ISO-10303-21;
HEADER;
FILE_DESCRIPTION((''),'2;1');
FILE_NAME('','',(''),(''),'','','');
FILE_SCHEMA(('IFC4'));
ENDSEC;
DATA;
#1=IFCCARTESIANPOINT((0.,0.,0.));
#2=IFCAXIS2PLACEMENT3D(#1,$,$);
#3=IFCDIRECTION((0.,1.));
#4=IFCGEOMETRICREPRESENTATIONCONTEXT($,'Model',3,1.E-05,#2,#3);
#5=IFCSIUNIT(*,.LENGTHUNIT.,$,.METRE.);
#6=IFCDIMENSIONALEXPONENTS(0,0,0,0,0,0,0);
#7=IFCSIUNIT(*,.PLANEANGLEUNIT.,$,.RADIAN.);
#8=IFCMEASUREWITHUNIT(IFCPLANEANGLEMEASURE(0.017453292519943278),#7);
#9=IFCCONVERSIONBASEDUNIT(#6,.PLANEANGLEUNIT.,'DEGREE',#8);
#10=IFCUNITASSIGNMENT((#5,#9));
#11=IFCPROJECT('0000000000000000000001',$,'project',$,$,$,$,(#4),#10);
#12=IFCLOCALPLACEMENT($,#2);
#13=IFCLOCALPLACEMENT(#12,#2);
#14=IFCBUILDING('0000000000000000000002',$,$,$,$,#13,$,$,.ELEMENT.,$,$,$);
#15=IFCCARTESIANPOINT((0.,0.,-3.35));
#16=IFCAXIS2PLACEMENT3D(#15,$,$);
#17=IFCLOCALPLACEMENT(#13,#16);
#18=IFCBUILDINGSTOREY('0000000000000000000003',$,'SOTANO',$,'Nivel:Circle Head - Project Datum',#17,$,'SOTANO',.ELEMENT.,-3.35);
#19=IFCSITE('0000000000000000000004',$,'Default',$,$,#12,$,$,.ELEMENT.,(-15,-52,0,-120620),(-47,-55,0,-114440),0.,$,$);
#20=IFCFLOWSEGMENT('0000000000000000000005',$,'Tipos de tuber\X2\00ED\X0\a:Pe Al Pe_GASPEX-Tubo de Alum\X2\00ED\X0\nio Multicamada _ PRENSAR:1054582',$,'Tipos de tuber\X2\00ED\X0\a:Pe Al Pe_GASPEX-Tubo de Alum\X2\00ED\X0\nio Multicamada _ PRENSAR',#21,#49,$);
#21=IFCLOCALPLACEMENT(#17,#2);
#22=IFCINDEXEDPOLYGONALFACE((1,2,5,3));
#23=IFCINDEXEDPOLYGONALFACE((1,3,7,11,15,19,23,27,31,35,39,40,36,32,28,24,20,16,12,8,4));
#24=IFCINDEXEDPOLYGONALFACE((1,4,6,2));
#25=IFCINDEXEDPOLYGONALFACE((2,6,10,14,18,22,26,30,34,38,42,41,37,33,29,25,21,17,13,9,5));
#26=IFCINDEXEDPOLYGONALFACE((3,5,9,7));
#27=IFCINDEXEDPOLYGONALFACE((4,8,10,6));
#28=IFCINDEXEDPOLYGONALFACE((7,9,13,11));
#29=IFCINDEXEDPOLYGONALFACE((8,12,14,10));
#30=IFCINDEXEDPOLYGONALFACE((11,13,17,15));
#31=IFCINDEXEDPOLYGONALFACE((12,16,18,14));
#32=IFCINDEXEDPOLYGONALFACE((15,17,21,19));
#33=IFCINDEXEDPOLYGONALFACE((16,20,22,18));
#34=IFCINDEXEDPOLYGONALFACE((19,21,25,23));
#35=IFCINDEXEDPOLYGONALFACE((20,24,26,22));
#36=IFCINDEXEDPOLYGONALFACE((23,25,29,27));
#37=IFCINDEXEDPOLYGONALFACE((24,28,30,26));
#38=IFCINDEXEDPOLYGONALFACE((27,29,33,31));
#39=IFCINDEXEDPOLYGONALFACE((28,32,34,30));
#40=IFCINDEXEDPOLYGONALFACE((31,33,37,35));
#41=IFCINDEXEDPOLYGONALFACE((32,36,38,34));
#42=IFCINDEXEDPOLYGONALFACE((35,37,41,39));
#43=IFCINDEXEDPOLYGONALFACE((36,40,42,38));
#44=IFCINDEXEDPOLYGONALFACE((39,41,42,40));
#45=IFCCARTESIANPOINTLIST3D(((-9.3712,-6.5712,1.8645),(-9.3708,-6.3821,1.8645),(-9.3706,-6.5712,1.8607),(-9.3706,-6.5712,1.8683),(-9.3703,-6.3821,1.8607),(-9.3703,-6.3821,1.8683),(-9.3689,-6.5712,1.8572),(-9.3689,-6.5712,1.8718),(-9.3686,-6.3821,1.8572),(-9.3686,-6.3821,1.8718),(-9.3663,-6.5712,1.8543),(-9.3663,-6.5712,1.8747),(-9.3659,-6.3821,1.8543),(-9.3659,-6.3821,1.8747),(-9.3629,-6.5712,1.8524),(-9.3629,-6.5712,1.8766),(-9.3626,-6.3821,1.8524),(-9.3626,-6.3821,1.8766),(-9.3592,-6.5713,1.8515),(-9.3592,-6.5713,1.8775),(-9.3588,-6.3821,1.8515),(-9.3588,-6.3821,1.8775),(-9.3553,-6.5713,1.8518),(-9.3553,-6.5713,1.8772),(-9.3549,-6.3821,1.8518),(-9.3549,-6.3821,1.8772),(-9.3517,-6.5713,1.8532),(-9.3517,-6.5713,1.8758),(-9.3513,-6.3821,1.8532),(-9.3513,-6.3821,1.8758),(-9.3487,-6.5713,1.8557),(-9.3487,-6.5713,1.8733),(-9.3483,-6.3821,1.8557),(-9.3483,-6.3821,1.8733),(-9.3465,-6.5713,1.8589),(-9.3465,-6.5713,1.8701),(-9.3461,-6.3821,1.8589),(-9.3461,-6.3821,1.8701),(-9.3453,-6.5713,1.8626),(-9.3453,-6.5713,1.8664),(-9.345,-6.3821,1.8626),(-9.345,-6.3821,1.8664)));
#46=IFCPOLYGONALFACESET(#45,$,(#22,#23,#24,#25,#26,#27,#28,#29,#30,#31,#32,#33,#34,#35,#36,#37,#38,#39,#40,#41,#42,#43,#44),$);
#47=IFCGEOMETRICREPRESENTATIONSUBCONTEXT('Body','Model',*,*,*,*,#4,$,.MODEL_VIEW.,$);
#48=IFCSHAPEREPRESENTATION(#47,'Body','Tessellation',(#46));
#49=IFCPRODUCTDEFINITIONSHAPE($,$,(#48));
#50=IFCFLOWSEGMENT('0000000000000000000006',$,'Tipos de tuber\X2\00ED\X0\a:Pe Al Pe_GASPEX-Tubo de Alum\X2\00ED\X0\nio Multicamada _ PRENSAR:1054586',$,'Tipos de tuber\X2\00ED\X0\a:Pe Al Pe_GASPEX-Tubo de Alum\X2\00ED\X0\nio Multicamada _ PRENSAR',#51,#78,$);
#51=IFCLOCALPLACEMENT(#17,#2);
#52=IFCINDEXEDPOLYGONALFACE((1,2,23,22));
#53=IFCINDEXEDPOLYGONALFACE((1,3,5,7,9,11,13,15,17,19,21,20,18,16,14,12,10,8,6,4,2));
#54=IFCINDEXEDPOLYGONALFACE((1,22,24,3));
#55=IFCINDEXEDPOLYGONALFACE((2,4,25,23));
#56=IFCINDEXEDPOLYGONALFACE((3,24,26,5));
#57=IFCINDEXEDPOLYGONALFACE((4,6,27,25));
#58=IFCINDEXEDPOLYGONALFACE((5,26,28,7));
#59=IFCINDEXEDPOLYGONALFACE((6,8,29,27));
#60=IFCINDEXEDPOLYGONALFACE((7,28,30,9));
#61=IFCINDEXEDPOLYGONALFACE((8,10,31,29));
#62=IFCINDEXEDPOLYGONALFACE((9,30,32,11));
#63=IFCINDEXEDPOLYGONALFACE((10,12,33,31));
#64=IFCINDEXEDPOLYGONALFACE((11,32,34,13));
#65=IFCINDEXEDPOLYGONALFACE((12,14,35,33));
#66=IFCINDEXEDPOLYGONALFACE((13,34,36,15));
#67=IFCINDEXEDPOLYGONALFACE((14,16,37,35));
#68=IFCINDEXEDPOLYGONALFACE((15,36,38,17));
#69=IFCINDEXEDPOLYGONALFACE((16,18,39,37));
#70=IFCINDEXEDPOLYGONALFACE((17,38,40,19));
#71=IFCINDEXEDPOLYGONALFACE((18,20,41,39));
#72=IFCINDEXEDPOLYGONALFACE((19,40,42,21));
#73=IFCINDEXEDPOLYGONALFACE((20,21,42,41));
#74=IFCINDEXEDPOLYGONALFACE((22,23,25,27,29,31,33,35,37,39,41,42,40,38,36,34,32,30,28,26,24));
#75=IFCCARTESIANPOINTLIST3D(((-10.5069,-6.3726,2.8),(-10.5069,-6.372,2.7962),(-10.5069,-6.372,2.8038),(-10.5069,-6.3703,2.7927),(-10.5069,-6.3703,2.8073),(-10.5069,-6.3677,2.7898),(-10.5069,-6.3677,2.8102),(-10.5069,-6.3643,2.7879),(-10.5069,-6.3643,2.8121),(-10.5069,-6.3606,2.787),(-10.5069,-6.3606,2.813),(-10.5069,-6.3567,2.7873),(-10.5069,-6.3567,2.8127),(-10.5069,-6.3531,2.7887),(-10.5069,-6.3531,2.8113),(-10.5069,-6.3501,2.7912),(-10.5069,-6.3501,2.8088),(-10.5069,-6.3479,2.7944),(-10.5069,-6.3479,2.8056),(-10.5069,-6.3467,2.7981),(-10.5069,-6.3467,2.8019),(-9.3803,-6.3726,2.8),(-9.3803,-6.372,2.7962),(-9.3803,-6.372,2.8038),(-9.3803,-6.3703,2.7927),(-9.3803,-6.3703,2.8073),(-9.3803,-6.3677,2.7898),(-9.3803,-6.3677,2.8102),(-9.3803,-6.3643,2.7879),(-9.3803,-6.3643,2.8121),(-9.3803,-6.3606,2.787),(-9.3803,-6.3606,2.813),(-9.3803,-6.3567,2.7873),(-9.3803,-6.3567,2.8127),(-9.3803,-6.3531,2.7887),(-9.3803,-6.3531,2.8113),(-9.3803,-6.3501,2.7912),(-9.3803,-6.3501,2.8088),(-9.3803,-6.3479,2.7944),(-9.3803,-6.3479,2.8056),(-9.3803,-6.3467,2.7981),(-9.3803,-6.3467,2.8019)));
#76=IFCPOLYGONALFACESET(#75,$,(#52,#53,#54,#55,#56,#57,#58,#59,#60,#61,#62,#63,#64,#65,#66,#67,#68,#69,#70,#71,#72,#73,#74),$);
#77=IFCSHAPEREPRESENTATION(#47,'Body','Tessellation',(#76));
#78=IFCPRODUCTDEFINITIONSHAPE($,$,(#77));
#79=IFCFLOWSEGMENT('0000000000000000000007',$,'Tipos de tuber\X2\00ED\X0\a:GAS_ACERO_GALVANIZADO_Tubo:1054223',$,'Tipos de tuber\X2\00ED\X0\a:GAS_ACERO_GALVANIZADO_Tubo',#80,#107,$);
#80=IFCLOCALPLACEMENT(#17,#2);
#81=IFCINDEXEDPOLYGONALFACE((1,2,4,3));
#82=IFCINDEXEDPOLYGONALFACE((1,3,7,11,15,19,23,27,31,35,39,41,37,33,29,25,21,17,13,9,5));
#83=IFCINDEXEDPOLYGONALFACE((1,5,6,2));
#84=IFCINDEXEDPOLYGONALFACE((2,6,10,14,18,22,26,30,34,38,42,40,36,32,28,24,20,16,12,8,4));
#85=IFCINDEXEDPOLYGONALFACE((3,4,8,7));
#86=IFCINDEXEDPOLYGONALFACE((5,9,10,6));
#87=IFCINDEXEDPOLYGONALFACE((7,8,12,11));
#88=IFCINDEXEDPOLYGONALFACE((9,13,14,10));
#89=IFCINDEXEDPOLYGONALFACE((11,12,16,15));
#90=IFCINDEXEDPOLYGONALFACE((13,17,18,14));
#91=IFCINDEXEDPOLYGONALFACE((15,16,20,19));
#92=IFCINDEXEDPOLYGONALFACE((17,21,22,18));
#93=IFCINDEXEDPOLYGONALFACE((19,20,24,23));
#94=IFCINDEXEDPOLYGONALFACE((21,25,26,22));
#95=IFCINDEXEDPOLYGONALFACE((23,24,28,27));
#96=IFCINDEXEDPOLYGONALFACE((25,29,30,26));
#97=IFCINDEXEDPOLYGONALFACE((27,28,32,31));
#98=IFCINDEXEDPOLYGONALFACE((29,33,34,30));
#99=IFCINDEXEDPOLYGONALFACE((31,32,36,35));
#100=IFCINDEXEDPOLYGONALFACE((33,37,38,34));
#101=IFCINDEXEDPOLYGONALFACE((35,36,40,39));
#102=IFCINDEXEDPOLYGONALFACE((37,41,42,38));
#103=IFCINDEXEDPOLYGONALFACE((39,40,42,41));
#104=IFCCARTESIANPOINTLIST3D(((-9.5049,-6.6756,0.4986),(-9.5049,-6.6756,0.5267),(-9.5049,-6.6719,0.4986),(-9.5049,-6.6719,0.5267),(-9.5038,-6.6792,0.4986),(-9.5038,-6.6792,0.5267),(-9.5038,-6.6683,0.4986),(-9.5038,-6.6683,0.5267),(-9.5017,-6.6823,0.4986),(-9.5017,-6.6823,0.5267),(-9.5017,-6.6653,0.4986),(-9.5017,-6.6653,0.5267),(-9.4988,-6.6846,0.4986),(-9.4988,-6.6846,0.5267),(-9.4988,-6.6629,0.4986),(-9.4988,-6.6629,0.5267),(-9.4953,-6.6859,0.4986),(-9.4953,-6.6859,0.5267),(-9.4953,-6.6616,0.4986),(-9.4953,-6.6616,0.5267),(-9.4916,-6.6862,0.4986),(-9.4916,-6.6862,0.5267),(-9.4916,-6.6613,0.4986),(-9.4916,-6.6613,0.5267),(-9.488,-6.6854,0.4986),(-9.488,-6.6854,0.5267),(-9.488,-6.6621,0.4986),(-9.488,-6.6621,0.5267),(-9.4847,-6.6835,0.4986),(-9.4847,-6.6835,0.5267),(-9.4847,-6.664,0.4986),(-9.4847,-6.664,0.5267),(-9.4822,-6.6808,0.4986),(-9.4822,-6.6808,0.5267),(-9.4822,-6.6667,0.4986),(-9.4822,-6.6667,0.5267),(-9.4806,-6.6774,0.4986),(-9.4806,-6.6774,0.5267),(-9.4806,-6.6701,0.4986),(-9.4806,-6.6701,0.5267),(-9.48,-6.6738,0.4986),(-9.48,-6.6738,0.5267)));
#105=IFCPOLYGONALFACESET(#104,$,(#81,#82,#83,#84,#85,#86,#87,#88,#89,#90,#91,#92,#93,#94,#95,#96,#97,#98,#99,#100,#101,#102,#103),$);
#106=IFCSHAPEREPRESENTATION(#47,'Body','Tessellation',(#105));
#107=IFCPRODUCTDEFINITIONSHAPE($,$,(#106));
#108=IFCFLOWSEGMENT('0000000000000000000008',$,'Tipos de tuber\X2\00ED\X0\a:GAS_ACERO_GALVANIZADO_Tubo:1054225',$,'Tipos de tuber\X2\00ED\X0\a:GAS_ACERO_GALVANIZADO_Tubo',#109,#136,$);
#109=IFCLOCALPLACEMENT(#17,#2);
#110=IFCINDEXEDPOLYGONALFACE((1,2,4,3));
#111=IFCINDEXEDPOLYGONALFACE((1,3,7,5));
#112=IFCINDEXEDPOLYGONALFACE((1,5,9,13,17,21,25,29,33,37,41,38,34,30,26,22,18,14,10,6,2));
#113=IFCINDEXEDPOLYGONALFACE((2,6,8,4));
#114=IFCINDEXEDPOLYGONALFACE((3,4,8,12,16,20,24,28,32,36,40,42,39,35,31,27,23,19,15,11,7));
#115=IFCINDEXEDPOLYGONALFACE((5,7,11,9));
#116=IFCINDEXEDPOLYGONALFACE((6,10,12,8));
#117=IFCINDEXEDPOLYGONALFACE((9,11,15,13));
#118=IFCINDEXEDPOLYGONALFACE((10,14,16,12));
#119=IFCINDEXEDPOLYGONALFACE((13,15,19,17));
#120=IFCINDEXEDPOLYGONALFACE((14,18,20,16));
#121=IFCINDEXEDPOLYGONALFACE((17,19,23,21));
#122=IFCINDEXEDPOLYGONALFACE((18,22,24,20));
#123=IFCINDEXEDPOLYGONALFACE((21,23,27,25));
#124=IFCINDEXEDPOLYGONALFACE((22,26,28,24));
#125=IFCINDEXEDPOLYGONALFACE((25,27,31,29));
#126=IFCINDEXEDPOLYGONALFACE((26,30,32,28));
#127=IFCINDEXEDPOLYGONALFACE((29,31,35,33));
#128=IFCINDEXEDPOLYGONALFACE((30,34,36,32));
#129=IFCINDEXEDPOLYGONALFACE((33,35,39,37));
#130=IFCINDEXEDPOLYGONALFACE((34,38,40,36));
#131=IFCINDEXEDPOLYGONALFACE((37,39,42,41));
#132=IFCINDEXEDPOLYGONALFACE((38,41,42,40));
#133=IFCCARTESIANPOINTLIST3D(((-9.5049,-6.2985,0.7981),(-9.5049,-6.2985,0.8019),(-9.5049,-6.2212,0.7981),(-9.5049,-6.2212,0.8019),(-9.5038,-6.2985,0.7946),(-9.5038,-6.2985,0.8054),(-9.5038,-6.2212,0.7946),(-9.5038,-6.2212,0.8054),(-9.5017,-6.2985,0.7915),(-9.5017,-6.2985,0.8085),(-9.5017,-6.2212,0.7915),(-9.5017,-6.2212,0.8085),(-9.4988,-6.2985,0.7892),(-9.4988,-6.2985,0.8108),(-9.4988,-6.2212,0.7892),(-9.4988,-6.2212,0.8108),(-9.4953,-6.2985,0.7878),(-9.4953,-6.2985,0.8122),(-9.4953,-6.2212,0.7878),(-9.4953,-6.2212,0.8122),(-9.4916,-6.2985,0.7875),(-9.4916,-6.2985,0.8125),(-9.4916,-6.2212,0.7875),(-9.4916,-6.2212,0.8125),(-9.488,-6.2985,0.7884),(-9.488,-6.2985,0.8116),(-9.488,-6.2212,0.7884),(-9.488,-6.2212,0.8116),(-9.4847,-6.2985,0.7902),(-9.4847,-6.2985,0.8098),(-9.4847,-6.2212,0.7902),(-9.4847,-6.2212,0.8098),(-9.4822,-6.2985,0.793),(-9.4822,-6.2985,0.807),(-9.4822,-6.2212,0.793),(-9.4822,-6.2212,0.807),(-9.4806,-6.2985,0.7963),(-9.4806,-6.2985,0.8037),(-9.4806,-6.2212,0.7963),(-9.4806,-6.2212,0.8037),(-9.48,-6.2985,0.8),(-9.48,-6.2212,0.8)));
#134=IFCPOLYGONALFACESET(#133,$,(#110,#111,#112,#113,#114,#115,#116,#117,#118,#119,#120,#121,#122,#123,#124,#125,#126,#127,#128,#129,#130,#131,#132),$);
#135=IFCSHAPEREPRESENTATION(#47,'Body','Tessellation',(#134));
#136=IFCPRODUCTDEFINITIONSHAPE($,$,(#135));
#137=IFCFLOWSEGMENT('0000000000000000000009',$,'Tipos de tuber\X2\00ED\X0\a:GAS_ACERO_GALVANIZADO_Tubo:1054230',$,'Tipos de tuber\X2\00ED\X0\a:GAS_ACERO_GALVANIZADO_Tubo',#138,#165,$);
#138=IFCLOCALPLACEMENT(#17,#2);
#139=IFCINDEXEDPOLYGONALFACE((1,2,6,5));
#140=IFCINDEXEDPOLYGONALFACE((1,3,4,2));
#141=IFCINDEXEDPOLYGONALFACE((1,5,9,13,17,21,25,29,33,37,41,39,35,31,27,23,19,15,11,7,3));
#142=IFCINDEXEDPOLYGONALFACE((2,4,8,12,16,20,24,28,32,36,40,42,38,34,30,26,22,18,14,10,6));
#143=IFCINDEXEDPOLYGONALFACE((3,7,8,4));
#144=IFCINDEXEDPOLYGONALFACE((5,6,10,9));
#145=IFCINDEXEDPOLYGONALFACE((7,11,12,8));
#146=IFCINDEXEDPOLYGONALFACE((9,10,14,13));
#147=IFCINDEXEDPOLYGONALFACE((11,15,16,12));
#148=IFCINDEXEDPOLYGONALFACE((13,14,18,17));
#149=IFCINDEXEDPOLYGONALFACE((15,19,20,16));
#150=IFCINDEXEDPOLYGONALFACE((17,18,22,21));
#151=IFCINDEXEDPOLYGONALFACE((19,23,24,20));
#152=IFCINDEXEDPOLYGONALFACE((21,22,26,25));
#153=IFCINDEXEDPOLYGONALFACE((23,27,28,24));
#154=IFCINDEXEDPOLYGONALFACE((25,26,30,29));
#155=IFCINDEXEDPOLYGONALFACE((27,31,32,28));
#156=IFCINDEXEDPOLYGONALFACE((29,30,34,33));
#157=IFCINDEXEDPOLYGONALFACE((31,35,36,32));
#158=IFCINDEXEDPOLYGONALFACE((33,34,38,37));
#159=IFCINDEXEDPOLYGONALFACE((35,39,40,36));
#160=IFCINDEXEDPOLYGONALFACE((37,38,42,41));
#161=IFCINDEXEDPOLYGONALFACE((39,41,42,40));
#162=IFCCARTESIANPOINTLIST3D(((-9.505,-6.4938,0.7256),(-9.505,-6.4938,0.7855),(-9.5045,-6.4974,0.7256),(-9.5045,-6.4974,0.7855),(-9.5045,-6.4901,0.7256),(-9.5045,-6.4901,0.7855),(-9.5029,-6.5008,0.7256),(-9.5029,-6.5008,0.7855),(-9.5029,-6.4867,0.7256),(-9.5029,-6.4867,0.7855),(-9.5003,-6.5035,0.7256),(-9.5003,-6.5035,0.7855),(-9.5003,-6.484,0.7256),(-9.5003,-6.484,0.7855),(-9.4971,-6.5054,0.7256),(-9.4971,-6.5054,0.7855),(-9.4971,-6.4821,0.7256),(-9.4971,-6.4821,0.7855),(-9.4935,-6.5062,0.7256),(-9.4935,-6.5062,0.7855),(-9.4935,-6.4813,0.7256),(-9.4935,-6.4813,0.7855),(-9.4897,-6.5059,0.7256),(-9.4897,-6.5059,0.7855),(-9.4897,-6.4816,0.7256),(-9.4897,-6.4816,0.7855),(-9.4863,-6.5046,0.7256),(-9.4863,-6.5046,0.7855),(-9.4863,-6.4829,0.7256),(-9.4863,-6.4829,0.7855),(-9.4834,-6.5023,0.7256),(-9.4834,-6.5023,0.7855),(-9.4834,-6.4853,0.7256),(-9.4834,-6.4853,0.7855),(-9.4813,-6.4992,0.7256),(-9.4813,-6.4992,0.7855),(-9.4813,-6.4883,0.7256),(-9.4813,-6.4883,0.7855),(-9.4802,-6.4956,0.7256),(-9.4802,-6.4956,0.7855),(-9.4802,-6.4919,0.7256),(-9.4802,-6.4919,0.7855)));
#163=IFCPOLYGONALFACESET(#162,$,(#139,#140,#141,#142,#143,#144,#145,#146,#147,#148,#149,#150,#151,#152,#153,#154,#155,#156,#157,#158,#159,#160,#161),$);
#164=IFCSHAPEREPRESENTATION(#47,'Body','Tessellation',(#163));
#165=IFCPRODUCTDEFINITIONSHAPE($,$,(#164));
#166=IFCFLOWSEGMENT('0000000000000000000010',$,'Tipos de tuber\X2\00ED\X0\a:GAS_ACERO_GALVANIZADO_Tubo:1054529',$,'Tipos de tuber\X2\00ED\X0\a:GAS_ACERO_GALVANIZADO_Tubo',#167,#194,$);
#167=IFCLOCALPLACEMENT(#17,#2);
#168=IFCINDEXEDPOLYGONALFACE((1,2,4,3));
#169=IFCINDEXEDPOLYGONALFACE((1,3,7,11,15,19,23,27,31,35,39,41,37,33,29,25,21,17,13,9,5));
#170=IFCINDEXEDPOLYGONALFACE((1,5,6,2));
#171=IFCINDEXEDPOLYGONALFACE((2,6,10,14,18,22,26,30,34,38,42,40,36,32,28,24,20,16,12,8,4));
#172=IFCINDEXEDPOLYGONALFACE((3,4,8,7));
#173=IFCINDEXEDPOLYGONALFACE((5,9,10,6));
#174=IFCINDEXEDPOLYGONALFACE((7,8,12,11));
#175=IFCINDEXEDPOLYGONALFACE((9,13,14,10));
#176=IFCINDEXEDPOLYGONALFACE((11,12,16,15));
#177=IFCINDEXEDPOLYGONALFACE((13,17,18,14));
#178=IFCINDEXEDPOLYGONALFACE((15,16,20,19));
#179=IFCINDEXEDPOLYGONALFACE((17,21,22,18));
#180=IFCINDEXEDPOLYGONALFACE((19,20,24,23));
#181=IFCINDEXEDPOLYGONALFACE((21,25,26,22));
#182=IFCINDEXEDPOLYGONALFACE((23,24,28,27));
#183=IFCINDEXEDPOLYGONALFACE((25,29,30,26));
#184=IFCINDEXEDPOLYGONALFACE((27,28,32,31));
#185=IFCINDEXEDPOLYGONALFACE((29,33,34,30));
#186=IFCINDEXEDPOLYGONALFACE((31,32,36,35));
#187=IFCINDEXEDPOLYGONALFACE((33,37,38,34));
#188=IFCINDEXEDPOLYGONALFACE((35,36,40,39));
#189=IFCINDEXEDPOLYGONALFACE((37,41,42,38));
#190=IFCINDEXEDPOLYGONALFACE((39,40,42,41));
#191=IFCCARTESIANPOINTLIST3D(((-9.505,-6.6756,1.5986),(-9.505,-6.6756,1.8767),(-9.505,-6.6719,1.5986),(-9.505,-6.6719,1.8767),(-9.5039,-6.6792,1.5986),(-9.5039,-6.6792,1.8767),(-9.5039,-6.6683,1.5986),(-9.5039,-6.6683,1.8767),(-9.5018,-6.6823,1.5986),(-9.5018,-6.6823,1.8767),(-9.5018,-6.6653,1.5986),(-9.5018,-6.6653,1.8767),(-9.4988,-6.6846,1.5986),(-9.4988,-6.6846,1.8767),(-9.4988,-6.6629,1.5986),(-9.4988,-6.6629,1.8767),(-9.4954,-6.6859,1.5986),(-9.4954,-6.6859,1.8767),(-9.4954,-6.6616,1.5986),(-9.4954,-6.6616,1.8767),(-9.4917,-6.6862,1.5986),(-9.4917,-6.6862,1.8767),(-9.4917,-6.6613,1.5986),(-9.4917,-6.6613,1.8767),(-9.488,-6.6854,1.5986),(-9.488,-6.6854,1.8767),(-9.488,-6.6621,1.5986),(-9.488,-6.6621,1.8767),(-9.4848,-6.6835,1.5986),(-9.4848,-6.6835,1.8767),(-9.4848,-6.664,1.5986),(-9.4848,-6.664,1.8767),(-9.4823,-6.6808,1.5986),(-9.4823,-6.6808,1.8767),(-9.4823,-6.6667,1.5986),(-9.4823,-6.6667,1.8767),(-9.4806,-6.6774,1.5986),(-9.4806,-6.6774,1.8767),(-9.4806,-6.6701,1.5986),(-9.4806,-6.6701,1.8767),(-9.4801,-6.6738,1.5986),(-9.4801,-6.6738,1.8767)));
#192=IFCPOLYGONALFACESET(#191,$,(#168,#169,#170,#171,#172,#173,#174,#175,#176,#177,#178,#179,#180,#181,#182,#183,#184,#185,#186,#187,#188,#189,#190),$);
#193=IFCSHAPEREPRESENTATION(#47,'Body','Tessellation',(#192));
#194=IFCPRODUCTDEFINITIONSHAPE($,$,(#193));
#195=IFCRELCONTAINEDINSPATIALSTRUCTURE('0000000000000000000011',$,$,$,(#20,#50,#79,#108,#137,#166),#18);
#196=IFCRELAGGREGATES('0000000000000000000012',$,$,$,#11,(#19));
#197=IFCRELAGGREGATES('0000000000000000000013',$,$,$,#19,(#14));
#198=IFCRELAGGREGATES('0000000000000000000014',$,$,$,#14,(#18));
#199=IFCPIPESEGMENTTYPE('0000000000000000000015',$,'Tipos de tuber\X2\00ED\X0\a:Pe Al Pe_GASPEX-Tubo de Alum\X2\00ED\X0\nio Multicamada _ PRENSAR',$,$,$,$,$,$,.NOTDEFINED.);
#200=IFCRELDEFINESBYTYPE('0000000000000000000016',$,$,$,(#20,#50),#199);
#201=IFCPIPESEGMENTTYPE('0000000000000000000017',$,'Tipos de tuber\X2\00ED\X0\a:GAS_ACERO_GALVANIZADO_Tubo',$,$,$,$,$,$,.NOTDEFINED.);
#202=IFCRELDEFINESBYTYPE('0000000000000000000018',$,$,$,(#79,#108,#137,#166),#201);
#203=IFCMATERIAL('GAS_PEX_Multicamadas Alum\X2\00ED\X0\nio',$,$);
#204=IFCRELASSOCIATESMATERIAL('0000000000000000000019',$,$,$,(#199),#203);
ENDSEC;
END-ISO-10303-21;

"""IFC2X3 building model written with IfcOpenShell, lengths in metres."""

from ifc_helpers import new_model, entity, si_unit, converted_unit, direction, frame, frame_2d, origin, origin_2d_with_axis, place, context, subcontext, project, spatial, circle, extrude, material, type_object, element, save


model = new_model("IFC2X3")

# Units and contexts
model_context = context("Model", 3, precision=1e-05, world=origin(), true_north=direction((0.0, 1.0)))
body_context = subcontext(model_context, "Body", "Model", "MODEL_VIEW")
ifc_project = project(units=[si_unit("LENGTHUNIT", "METRE"), converted_unit("PLANEANGLEUNIT", "DEGREE", entity("IfcPlaneAngleMeasure", 0.017453292519943278), si_unit("PLANEANGLEUNIT", "RADIAN"), dimensions=[0, 0, 0, 0, 0, 0, 0])], contexts=[model_context])

# Site, building, storey
site_placement = place(None, origin())
site = spatial("IfcSite", under=ifc_project, at=site_placement, Name="Default", CompositionType="ELEMENT", RefLatitude=(-15, -52, 0, -120620), RefLongitude=(-47, -55, 0, -114440), RefElevation=0.0)
building_placement = place(site_placement, origin())
building = spatial("IfcBuilding", under=site, at=building_placement, CompositionType="ELEMENT")
storey_placement = place(building_placement, frame((0.0, 0.0, -3.35)))
storey = spatial("IfcBuildingStorey", under=building, at=storey_placement, Name="SOTANO", ObjectType="Nivel:Circle Head - Project Datum", LongName="SOTANO", CompositionType="ELEMENT", Elevation=-3.35)

# Flow segments
ifc_material = material(Name="GAS_PEX_Multicamadas Alumínio")
pipe_segment_type_1 = type_object("IfcPipeSegmentType", Name="Tipos de tubería:Pe Al Pe_GASPEX-Tubo de Alumínio Multicamada _ PRENSAR", PredefinedType="NOTDEFINED", material=ifc_material)
flow_segment_1_placement = place(storey_placement, origin())
element("IfcFlowSegment", 1, at=flow_segment_1_placement, inside=storey, type_object=pipe_segment_type_1, Name="Tipos de tubería:Pe Al Pe_GASPEX-Tubo de Alumínio Multicamada _ PRENSAR:1054582", ObjectType="Tipos de tubería:Pe Al Pe_GASPEX-Tubo de Alumínio Multicamada _ PRENSAR", context=body_context, shape_type="SweptSolid", body=[
    extrude(circle(Radius=0.013, at=origin_2d_with_axis()), frame((-9.3582, -6.5713, 1.8645), z_axis=(0.0019, 0.999998, 0.0), x_axis=(-0.999998, 0.0019, 0.0)), (0.0, 0.0, 1.0), 0.1892),
])
flow_segment_2_placement = place(storey_placement, origin())
element("IfcFlowSegment", 2, at=flow_segment_2_placement, inside=storey, type_object=pipe_segment_type_1, Name="Tipos de tubería:Pe Al Pe_GASPEX-Tubo de Alumínio Multicamada _ PRENSAR:1054586", ObjectType="Tipos de tubería:Pe Al Pe_GASPEX-Tubo de Alumínio Multicamada _ PRENSAR", context=body_context, shape_type="SweptSolid", body=[
    extrude(circle(Radius=0.013, at=origin_2d_with_axis()), frame((-10.5069, -6.3596, 2.8), z_axis=(1.0, -0.000001, 0.0), x_axis=(-0.000001, -1.0, 0.0)), (0.0, 0.0, 1.0), 1.1266),
])
pipe_segment_type_2 = type_object("IfcPipeSegmentType", Name="Tipos de tubería:GAS_ACERO_GALVANIZADO_Tubo", PredefinedType="NOTDEFINED")
flow_segment_3_placement = place(storey_placement, origin())
element("IfcFlowSegment", 3, at=flow_segment_3_placement, inside=storey, type_object=pipe_segment_type_2, Name="Tipos de tubería:GAS_ACERO_GALVANIZADO_Tubo:1054223", ObjectType="Tipos de tubería:GAS_ACERO_GALVANIZADO_Tubo", context=body_context, shape_type="SweptSolid", body=[
    extrude(circle(Radius=0.0125, at=origin_2d_with_axis()), frame((-9.4925, -6.6738, 0.4986)), (0.0, 0.0, 1.0), 0.0281),
])
flow_segment_4_placement = place(storey_placement, origin())
element("IfcFlowSegment", 4, at=flow_segment_4_placement, inside=storey, type_object=pipe_segment_type_2, Name="Tipos de tubería:GAS_ACERO_GALVANIZADO_Tubo:1054225", ObjectType="Tipos de tubería:GAS_ACERO_GALVANIZADO_Tubo", context=body_context, shape_type="SweptSolid", body=[
    extrude(circle(Radius=0.0125, at=origin_2d_with_axis()), frame((-9.4925, -6.2985, 0.8), z_axis=(-0.000003, 1.0, 0.0), x_axis=(1.0, 0.000003, 0.0)), (0.0, 0.0, 1.0), 0.0773),
])
flow_segment_5_placement = place(storey_placement, origin())
element("IfcFlowSegment", 5, at=flow_segment_5_placement, inside=storey, type_object=pipe_segment_type_2, Name="Tipos de tubería:GAS_ACERO_GALVANIZADO_Tubo:1054230", ObjectType="Tipos de tubería:GAS_ACERO_GALVANIZADO_Tubo", context=body_context, shape_type="SweptSolid", body=[
    extrude(circle(Radius=0.0125, at=origin_2d_with_axis()), frame((-9.4925, -6.4938, 0.7256), z_axis=(0.0, 0.0, 1.0), x_axis=(-1.0, 0.0, 0.0)), (0.0, 0.0, 1.0), 0.0599),
])
flow_segment_6_placement = place(storey_placement, origin())
element("IfcFlowSegment", 6, at=flow_segment_6_placement, inside=storey, type_object=pipe_segment_type_2, Name="Tipos de tubería:GAS_ACERO_GALVANIZADO_Tubo:1054529", ObjectType="Tipos de tubería:GAS_ACERO_GALVANIZADO_Tubo", context=body_context, shape_type="SweptSolid", body=[
    extrude(circle(Radius=0.0125, at=frame_2d((0.0, 0.0), x_axis=(1.0, 0.0))), frame((-9.4926, -6.6738, 1.5986)), (0.0, 0.0, 1.0), 0.2781),
])

save(model, "model.ifc")
